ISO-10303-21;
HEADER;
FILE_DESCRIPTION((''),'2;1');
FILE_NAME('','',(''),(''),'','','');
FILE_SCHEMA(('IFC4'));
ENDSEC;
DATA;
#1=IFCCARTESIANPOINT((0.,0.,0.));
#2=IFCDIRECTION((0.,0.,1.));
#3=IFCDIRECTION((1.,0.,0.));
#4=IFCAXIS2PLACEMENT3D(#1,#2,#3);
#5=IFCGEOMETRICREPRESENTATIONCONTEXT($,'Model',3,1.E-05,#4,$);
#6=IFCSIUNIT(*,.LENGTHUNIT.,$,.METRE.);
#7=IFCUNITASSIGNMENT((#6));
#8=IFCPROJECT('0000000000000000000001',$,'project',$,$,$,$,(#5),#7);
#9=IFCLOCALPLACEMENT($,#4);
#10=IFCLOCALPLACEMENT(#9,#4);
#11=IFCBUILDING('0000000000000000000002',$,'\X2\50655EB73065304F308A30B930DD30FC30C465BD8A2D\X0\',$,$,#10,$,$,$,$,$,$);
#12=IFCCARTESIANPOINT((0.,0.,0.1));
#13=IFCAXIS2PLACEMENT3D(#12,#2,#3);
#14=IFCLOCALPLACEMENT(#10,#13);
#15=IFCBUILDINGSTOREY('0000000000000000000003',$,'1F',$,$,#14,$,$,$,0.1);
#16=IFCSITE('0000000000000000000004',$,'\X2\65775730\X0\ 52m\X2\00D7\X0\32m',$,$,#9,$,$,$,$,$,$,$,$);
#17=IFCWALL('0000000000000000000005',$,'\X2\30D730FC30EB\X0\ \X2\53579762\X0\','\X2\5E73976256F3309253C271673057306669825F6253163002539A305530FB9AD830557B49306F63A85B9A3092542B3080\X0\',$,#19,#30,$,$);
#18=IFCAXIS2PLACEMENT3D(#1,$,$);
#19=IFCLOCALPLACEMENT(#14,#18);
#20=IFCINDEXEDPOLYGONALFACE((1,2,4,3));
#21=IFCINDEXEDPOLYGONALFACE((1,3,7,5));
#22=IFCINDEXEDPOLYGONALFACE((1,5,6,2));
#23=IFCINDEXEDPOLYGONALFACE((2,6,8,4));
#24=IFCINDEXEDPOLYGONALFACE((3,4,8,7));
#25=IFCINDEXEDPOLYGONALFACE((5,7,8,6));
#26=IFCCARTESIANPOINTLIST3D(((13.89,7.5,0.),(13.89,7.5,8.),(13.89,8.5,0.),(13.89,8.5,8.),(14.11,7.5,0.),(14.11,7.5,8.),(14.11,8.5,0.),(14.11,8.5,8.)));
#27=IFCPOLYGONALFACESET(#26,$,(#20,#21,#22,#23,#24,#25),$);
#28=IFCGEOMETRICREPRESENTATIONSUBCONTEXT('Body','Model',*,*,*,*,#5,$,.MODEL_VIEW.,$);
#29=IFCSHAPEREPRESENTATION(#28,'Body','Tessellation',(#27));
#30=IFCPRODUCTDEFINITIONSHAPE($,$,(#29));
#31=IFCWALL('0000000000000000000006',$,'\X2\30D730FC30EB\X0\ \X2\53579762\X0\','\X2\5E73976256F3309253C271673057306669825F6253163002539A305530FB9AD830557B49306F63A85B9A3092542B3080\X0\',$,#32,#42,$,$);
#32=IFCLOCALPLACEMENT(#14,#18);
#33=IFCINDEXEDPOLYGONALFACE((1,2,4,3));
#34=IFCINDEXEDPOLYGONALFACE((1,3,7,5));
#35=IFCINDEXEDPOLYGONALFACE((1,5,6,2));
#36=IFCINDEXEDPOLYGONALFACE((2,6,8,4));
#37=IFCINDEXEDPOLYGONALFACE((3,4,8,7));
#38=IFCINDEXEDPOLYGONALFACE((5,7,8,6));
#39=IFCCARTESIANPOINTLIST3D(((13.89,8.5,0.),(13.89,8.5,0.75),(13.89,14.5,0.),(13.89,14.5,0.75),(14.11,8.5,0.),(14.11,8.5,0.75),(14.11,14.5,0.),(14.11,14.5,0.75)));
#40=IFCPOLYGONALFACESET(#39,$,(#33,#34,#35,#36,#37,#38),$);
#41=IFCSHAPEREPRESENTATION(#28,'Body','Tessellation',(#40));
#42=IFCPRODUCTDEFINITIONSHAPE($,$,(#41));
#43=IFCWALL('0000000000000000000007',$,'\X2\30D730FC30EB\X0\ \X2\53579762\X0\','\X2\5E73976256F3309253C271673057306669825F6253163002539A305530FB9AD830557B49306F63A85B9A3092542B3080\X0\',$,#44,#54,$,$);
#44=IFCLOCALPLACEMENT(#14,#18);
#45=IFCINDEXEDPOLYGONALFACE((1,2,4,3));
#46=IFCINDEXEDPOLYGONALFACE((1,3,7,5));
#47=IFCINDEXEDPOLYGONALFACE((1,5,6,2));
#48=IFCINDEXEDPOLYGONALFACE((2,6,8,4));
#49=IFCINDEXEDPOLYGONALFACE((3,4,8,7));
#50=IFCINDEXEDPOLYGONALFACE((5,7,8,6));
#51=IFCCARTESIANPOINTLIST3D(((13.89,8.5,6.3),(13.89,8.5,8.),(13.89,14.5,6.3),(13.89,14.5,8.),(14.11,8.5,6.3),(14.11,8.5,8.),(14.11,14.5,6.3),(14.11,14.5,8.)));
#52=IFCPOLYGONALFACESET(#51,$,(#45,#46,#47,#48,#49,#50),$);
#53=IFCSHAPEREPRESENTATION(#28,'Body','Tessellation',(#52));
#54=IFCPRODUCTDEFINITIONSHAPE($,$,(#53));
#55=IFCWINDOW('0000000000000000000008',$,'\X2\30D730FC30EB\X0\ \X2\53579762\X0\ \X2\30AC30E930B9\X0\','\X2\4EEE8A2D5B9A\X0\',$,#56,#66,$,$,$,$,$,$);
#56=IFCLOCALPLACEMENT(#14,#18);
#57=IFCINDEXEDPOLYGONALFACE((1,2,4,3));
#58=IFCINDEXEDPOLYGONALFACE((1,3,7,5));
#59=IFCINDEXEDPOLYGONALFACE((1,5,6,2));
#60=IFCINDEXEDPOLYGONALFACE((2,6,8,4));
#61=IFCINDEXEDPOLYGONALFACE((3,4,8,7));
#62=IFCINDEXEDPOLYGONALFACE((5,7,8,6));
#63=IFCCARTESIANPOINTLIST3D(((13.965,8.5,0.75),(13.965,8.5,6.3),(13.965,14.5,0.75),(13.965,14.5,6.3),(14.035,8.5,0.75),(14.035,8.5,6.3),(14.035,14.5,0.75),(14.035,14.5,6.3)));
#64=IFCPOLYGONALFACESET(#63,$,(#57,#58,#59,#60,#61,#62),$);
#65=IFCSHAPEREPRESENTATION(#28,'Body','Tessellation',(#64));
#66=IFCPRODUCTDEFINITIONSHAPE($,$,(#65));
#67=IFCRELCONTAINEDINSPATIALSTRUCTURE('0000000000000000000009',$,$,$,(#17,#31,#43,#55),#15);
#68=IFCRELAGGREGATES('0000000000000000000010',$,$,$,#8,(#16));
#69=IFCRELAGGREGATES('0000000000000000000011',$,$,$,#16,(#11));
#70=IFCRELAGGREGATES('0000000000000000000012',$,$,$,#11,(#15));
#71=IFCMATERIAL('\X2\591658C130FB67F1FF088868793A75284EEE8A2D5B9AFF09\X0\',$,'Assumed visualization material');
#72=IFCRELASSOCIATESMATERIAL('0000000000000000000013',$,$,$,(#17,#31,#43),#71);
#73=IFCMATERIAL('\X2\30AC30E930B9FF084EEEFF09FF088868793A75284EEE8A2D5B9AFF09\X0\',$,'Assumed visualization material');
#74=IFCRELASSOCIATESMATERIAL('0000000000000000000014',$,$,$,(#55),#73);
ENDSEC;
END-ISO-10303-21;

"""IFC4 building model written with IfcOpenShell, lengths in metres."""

from ifc_helpers import new_model, si_unit, frame, origin_with_axes, place, context, subcontext, project, spatial, rectangle, extrude, material, element, save


model = new_model("IFC4")

# Units and contexts
model_context = context("Model", 3, precision=1e-05, world=origin_with_axes())
body_context = subcontext(model_context, "Body", "Model", "MODEL_VIEW")
ifc_project = project(units=[si_unit("LENGTHUNIT", "METRE")], contexts=[model_context])

# Site, building, storey
site_placement = place(None, origin_with_axes())
site = spatial("IfcSite", under=ifc_project, at=site_placement, Name="敷地 52m×32m")
building_placement = place(site_placement, origin_with_axes())
building = spatial("IfcBuilding", under=site, at=building_placement, Name="健康づくりスポーツ施設")
storey_placement = place(building_placement, frame((0.0, 0.0, 0.1), z_axis=(0.0, 0.0, 1.0), x_axis=(1.0, 0.0, 0.0)))
storey = spatial("IfcBuildingStorey", under=building, at=storey_placement, Name="1F", Elevation=0.1)

# Shared definitions
ifc_material_1 = material(Name="外壁・柱（表示用仮設定）", Category="Assumed visualization material")

# Shared definitions
ifc_material_2 = material(Name="ガラス（仮）（表示用仮設定）", Category="Assumed visualization material")

# Walls
wall_1_placement = place(storey_placement, frame((14.0, 8.0, 0.0), z_axis=(0.0, 0.0, 1.0), x_axis=(1.0, 0.0, 0.0)))
element("IfcWall", 1, at=wall_1_placement, inside=storey, material=ifc_material_1, Name="プール 南面", Description="平面図を参照して概形化。厚さ・高さ等は推定を含む", context=body_context, shape_type="SweptSolid", body=[
    extrude(rectangle(XDim=0.22, YDim=1.0), origin_with_axes(), (0.0, 0.0, 1.0), 8.0),
])
wall_2_placement = place(storey_placement, frame((14.0, 11.5, 0.0), z_axis=(0.0, 0.0, 1.0), x_axis=(1.0, 0.0, 0.0)))
element("IfcWall", 2, at=wall_2_placement, inside=storey, material=ifc_material_1, Name="プール 南面", Description="平面図を参照して概形化。厚さ・高さ等は推定を含む", context=body_context, shape_type="SweptSolid", body=[
    extrude(rectangle(XDim=0.22, YDim=6.0), origin_with_axes(), (0.0, 0.0, 1.0), 0.75),
])
wall_3_placement = place(storey_placement, frame((14.0, 11.5, 6.3), z_axis=(0.0, 0.0, 1.0), x_axis=(1.0, 0.0, 0.0)))
element("IfcWall", 3, at=wall_3_placement, inside=storey, material=ifc_material_1, Name="プール 南面", Description="平面図を参照して概形化。厚さ・高さ等は推定を含む", context=body_context, shape_type="SweptSolid", body=[
    extrude(rectangle(XDim=0.22, YDim=6.0), origin_with_axes(), (0.0, 0.0, 1.0), 1.7),
])

# Window
window_1_placement = place(storey_placement, frame((14.0, 11.5, 0.75), z_axis=(0.0, 0.0, 1.0), x_axis=(1.0, 0.0, 0.0)))
element("IfcWindow", 4, at=window_1_placement, inside=storey, material=ifc_material_2, Name="プール 南面 ガラス", Description="仮設定", context=body_context, shape_type="SweptSolid", body=[
    extrude(rectangle(XDim=0.07, YDim=6.0), origin_with_axes(), (0.0, 0.0, 1.0), 5.55),
])

save(model, "model.ifc")
